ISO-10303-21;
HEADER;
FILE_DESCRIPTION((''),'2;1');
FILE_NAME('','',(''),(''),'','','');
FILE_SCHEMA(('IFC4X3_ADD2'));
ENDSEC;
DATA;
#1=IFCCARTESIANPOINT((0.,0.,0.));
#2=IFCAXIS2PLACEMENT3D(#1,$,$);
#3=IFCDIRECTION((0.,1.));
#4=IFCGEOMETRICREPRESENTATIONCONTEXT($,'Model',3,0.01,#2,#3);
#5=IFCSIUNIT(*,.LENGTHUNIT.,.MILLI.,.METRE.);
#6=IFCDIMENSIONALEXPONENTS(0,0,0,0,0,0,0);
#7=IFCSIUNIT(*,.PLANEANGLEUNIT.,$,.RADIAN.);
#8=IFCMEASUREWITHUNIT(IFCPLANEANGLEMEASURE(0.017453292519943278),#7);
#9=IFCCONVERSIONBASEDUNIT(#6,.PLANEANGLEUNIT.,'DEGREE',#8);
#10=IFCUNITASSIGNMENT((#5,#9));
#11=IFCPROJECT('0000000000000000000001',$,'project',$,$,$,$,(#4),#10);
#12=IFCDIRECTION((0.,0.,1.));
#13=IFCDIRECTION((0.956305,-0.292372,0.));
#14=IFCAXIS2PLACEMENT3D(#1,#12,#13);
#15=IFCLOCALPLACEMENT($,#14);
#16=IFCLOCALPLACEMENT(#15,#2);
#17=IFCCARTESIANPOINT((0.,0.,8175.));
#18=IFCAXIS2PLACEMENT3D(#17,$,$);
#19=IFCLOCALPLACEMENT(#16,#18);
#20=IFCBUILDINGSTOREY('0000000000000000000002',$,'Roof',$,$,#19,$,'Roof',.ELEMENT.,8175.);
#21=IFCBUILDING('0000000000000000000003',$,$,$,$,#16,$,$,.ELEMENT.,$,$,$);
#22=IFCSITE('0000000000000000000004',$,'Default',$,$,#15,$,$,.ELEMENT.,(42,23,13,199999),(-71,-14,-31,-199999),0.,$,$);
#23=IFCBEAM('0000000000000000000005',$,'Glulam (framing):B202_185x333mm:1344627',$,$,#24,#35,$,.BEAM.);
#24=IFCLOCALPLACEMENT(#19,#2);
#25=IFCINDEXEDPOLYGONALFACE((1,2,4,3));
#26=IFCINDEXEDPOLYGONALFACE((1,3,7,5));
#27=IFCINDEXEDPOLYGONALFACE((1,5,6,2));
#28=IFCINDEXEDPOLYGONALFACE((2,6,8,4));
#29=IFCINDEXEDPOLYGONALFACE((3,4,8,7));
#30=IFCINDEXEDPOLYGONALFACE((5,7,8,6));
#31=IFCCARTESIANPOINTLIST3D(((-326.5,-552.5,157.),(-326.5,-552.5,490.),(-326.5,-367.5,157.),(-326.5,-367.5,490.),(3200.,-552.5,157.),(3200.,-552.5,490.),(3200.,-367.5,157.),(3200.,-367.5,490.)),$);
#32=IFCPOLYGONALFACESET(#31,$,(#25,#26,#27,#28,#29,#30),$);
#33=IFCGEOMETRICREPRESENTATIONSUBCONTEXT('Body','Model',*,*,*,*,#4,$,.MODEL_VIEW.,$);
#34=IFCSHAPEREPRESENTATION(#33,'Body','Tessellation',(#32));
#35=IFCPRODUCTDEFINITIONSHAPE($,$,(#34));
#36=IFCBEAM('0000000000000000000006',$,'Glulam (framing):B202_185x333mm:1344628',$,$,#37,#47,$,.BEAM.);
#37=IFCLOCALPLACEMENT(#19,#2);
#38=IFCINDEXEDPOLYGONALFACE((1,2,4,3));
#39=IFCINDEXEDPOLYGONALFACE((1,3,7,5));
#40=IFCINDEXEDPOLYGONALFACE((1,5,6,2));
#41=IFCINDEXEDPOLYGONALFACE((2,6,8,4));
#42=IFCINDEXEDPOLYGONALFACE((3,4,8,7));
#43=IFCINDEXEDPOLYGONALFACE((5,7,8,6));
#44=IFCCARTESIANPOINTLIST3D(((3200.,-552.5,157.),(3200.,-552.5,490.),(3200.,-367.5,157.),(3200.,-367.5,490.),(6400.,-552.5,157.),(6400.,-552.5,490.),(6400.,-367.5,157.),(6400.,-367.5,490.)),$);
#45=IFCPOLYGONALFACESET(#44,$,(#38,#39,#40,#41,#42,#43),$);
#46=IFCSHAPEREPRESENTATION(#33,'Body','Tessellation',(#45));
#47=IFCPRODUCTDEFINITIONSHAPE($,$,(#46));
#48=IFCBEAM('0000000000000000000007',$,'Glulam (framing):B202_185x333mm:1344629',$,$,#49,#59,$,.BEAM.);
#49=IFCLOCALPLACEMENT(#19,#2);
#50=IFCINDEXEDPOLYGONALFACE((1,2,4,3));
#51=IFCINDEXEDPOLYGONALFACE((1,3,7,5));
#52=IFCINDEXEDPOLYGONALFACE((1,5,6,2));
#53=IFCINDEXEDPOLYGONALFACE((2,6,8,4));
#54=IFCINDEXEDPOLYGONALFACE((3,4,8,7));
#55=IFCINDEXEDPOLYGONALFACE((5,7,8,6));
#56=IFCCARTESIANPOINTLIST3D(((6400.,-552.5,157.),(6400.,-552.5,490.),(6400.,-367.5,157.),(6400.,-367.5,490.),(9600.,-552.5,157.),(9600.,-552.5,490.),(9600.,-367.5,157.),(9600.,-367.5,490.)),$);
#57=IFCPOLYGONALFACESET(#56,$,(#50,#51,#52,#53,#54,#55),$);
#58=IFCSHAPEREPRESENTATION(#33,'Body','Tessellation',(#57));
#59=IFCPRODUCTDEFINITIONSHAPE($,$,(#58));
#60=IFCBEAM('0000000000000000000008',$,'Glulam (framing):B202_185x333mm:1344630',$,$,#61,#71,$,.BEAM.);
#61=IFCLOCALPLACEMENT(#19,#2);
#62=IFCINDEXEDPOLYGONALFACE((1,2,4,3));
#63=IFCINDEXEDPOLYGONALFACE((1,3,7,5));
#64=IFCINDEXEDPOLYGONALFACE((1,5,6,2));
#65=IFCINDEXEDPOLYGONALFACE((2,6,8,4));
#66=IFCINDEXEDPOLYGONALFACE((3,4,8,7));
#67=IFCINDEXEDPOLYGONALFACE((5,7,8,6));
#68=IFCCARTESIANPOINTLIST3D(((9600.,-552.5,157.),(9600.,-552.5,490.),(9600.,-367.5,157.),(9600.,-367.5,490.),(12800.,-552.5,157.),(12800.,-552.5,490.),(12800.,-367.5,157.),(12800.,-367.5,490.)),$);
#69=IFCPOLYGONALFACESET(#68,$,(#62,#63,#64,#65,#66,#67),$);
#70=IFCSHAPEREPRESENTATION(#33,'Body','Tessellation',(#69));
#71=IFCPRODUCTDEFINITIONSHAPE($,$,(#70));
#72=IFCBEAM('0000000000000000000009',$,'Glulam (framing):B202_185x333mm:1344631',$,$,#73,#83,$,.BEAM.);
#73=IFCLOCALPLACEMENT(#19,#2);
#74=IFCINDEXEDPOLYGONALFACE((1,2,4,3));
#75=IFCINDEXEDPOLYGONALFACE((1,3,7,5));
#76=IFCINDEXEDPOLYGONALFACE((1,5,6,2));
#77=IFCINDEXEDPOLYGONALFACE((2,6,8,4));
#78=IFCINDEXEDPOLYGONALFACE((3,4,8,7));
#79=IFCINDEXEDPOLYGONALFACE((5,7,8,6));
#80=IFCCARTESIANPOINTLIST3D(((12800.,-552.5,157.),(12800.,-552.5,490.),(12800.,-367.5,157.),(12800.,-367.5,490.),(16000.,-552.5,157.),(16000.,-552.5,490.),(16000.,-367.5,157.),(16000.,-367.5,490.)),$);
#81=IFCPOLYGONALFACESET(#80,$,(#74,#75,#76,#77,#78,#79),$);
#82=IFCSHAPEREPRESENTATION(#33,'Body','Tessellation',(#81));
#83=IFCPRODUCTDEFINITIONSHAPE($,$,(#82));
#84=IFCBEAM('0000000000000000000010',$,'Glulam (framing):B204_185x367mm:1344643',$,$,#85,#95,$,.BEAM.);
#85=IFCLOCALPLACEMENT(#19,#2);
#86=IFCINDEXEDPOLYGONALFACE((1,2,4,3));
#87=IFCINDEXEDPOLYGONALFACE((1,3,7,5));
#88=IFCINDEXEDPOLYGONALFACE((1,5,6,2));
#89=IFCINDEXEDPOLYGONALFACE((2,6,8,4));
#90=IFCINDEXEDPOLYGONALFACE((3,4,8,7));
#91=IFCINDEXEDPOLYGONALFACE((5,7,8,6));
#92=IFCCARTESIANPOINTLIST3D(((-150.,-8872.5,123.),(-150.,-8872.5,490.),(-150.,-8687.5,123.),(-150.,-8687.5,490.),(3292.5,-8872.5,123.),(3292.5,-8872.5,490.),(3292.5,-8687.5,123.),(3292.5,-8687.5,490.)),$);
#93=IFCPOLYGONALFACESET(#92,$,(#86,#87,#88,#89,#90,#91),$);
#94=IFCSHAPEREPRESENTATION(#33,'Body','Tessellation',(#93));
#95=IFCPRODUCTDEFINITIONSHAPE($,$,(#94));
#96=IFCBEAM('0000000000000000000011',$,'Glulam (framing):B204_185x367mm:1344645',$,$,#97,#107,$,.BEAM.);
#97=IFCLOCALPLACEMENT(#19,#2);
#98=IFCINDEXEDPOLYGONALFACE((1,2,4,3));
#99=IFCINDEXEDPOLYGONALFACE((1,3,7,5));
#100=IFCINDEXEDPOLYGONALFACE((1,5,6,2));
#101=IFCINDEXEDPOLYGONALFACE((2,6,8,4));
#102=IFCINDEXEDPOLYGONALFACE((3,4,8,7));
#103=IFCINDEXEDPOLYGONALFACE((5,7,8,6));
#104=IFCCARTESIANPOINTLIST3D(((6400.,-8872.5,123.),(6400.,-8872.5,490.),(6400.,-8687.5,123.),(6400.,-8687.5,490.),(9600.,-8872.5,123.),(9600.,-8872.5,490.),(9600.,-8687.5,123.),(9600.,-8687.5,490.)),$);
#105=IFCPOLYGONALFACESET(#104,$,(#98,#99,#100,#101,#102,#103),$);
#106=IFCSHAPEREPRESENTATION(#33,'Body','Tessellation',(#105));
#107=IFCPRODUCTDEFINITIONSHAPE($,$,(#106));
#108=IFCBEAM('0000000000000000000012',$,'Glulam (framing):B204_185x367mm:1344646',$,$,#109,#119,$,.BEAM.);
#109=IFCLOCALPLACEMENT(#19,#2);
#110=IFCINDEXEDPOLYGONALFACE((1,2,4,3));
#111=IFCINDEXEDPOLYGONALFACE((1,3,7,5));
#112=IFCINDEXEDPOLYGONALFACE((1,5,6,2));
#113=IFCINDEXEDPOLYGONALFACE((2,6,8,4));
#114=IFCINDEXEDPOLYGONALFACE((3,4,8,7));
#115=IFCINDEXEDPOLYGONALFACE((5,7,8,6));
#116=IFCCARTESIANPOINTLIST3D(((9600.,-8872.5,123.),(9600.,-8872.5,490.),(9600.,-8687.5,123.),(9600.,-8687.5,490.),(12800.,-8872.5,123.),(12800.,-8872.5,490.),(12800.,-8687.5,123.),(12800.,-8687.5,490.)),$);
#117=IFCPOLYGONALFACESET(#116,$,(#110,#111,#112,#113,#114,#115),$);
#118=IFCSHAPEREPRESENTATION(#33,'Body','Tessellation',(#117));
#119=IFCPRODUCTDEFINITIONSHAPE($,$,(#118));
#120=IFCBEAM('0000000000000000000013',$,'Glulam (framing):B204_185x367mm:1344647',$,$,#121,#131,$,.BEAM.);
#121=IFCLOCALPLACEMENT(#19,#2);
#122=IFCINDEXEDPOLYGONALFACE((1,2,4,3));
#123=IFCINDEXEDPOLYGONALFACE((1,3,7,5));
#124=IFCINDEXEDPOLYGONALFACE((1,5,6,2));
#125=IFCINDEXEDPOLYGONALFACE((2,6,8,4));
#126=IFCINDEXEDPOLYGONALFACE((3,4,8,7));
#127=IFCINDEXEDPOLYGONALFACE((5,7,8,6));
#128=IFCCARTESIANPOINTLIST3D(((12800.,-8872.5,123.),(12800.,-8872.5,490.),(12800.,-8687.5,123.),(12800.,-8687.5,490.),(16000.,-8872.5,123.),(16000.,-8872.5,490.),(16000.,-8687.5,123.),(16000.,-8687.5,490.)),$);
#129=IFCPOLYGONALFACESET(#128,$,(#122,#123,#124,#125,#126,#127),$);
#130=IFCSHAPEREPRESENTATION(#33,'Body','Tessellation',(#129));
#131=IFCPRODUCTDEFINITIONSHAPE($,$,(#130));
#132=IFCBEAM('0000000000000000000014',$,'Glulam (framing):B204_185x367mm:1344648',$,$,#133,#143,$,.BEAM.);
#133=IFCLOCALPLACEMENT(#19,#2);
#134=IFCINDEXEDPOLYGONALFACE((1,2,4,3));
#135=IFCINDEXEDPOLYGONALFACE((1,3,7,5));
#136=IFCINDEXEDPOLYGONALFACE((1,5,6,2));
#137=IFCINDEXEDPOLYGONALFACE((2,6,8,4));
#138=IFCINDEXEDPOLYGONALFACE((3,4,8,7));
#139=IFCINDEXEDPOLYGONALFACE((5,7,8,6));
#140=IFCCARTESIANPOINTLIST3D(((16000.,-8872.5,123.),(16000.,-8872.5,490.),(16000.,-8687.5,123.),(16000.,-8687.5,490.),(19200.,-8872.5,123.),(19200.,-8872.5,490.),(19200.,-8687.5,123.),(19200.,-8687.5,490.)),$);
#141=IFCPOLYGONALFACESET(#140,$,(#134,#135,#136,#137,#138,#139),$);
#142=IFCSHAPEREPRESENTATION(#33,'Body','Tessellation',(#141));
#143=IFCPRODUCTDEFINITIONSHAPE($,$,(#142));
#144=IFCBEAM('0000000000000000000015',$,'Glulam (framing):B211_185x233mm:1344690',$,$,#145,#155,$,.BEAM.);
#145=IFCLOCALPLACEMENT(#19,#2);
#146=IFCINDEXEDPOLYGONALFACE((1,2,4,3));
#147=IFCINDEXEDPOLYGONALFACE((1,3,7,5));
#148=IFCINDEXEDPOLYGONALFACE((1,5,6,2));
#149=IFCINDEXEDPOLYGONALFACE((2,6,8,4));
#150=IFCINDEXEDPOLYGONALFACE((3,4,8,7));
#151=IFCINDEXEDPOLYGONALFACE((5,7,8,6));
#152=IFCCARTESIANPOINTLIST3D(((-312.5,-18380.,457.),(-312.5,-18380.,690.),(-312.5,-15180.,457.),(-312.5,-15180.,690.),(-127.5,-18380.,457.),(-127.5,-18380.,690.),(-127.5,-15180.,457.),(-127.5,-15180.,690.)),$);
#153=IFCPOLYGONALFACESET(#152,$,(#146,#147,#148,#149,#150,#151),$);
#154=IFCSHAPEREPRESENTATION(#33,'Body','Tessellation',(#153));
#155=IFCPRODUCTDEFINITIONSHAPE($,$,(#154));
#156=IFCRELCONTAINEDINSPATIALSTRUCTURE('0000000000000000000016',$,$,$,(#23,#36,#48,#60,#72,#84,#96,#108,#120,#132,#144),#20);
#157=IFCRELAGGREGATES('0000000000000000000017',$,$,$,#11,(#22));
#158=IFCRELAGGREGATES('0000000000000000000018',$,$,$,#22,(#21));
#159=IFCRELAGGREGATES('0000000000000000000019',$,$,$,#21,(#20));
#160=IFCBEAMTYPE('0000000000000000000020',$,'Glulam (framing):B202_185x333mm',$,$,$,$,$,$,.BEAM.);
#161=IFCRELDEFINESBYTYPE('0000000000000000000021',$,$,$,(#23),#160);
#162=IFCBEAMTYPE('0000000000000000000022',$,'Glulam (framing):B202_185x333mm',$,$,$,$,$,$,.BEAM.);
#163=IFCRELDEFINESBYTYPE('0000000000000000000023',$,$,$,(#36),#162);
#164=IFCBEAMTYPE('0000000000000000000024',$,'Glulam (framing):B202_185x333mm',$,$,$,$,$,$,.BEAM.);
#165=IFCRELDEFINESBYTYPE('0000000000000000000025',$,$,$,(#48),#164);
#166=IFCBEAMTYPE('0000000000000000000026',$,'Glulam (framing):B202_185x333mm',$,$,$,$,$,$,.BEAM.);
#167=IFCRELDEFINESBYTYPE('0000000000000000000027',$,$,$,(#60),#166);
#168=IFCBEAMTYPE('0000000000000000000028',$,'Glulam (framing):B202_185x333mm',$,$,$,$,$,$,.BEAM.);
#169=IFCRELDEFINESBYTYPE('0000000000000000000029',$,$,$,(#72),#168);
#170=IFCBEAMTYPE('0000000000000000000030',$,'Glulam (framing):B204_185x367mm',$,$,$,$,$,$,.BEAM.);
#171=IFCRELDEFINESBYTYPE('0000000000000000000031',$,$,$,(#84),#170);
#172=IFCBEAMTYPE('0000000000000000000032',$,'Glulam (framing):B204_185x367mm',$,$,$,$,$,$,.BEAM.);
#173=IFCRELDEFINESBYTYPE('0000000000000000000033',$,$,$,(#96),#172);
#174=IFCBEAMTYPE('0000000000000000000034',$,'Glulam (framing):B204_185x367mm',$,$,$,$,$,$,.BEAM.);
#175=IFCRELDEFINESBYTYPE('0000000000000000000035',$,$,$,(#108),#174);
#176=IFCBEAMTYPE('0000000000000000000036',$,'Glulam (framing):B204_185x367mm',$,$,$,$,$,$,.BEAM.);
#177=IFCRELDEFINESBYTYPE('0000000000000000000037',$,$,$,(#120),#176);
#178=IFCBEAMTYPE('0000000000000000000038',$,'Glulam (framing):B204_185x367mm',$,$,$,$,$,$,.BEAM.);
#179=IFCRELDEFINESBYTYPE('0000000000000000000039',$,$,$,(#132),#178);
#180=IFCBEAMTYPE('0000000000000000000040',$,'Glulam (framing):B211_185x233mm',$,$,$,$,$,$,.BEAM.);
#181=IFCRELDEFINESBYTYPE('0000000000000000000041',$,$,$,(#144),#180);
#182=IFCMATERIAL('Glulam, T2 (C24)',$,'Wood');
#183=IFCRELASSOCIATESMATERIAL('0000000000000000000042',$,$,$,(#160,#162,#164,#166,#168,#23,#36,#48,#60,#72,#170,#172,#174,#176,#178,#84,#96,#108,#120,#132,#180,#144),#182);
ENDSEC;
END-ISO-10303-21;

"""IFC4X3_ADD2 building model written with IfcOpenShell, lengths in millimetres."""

from ifc_helpers import new_model, entity, si_unit, converted_unit, direction, frame, origin, origin_2d_with_axis, place, context, subcontext, project, spatial, rectangle, extrude, source, transform, mapped, material, material_profile, profile_set, profile_usage, type_object, type_shapes, element, save


model = new_model("IFC4X3_ADD2")

# Units and contexts
model_context = context("Model", 3, precision=0.01, world=origin(), true_north=direction((0.0, 1.0)))
body_context = subcontext(model_context, "Body", "Model", "MODEL_VIEW")
ifc_project = project(units=[si_unit("LENGTHUNIT", "METRE", prefix="MILLI"), converted_unit("PLANEANGLEUNIT", "DEGREE", entity("IfcPlaneAngleMeasure", 0.017453292519943278), si_unit("PLANEANGLEUNIT", "RADIAN"), dimensions=[0, 0, 0, 0, 0, 0, 0])], contexts=[model_context])

# Site, building, storey
site_placement = place(None, frame((0.0, 0.0, 0.0), z_axis=(0.0, 0.0, 1.0), x_axis=(0.956305, -0.292372, 0.0)))
site = spatial("IfcSite", under=ifc_project, at=site_placement, Name="Default", CompositionType="ELEMENT", RefLatitude=(42, 23, 13, 199999), RefLongitude=(-71, -14, -31, -199999), RefElevation=0.0)
building_placement = place(site_placement, origin())
building = spatial("IfcBuilding", under=site, at=building_placement, CompositionType="ELEMENT")
storey_placement = place(building_placement, frame((0.0, 0.0, 8175.0)))
storey = spatial("IfcBuildingStorey", under=building, at=storey_placement, Name="Roof", LongName="Roof", CompositionType="ELEMENT", Elevation=8175.0)

# Beams
ifc_material_1 = material(Name="Glulam, T2 (C24)", Category="Wood")
ifc_material_profile_1 = material_profile(ifc_material_1, rectangle(XDim=3526.5, YDim=185.0, at=origin_2d_with_axis()), Name="B202_185x333mm")
ifc_profile_set_1 = profile_set([ifc_material_profile_1], Name="B202_185x333mm")
ifc_profile_usage_1 = profile_usage(ifc_profile_set_1, cardinal=8)
beam_type_1 = type_object("IfcBeamType", Name="Glulam (framing):B202_185x333mm", PredefinedType="BEAM", material=ifc_profile_set_1)
shared_shape_1 = source(origin(), body_context, "Body", "SweptSolid", [
    extrude(rectangle(XDim=3526.5, YDim=185.0, at=origin_2d_with_axis()), frame((163.2, 0.0, -166.5), z_axis=(0.0, 0.0, 1.0), x_axis=(-1.0, 0.0, 0.0)), (0.0, 0.0, 1.0), 333.0),
])
type_shapes(beam_type_1, [shared_shape_1])
beam_1_placement = place(storey_placement, frame((1600.0, -460.0, 323.5), z_axis=(0.0, 0.0, 1.0), x_axis=(-1.0, 0.0, 0.0)))
element("IfcBeam", 1, at=beam_1_placement, inside=storey, type_object=beam_type_1, material=ifc_profile_usage_1, Name="Glulam (framing):B202_185x333mm:1344627", PredefinedType="BEAM", context=body_context, shape_type="MappedRepresentation", body=[
    mapped(shared_shape_1, transform((0.0, 0.0, 0.0), scale=1.0)),
])
beam_type_2 = type_object("IfcBeamType", Name="Glulam (framing):B202_185x333mm", PredefinedType="BEAM", material=ifc_profile_set_1)
shared_shape_2 = source(origin(), body_context, "Body", "SweptSolid", [
    extrude(rectangle(XDim=3200.0, YDim=185.0, at=origin_2d_with_axis()), frame((0.0, 0.0, -166.5), z_axis=(0.0, 0.0, 1.0), x_axis=(-1.0, 0.0, 0.0)), (0.0, 0.0, 1.0), 333.0),
])
type_shapes(beam_type_2, [shared_shape_2])
beam_2_placement = place(storey_placement, frame((4800.0, -460.0, 323.5), z_axis=(0.0, 0.0, 1.0), x_axis=(-1.0, 0.0, 0.0)))
element("IfcBeam", 2, at=beam_2_placement, inside=storey, type_object=beam_type_2, material=ifc_profile_usage_1, Name="Glulam (framing):B202_185x333mm:1344628", PredefinedType="BEAM", context=body_context, shape_type="MappedRepresentation", body=[
    mapped(shared_shape_2, transform((0.0, 0.0, 0.0), scale=1.0)),
])
beam_type_3 = type_object("IfcBeamType", Name="Glulam (framing):B202_185x333mm", PredefinedType="BEAM", material=ifc_profile_set_1)
shared_shape_3 = source(origin(), body_context, "Body", "SweptSolid", [
    extrude(rectangle(XDim=3200.0, YDim=185.0, at=origin_2d_with_axis()), frame((0.0, 0.0, -166.5), z_axis=(0.0, 0.0, 1.0), x_axis=(-1.0, 0.0, 0.0)), (0.0, 0.0, 1.0), 333.0),
])
type_shapes(beam_type_3, [shared_shape_3])
beam_3_placement = place(storey_placement, frame((8000.0, -460.0, 323.5), z_axis=(0.0, 0.0, 1.0), x_axis=(-1.0, 0.0, 0.0)))
element("IfcBeam", 3, at=beam_3_placement, inside=storey, type_object=beam_type_3, material=ifc_profile_usage_1, Name="Glulam (framing):B202_185x333mm:1344629", PredefinedType="BEAM", context=body_context, shape_type="MappedRepresentation", body=[
    mapped(shared_shape_3, transform((0.0, 0.0, 0.0), scale=1.0)),
])
beam_type_4 = type_object("IfcBeamType", Name="Glulam (framing):B202_185x333mm", PredefinedType="BEAM", material=ifc_profile_set_1)
shared_shape_4 = source(origin(), body_context, "Body", "SweptSolid", [
    extrude(rectangle(XDim=3200.0, YDim=185.0, at=origin_2d_with_axis()), frame((0.0, 0.0, -166.5), z_axis=(0.0, 0.0, 1.0), x_axis=(-1.0, 0.0, 0.0)), (0.0, 0.0, 1.0), 333.0),
])
type_shapes(beam_type_4, [shared_shape_4])
beam_4_placement = place(storey_placement, frame((11200.0, -460.0, 323.5), z_axis=(0.0, 0.0, 1.0), x_axis=(-1.0, 0.0, 0.0)))
element("IfcBeam", 4, at=beam_4_placement, inside=storey, type_object=beam_type_4, material=ifc_profile_usage_1, Name="Glulam (framing):B202_185x333mm:1344630", PredefinedType="BEAM", context=body_context, shape_type="MappedRepresentation", body=[
    mapped(shared_shape_4, transform((0.0, 0.0, 0.0), scale=1.0)),
])
beam_type_5 = type_object("IfcBeamType", Name="Glulam (framing):B202_185x333mm", PredefinedType="BEAM", material=ifc_profile_set_1)
shared_shape_5 = source(origin(), body_context, "Body", "SweptSolid", [
    extrude(rectangle(XDim=3200.0, YDim=185.0, at=origin_2d_with_axis()), frame((0.0, 0.0, -166.5), z_axis=(0.0, 0.0, 1.0), x_axis=(-1.0, 0.0, 0.0)), (0.0, 0.0, 1.0), 333.0),
])
type_shapes(beam_type_5, [shared_shape_5])
beam_5_placement = place(storey_placement, frame((14400.0, -460.0, 323.5), z_axis=(0.0, 0.0, 1.0), x_axis=(-1.0, 0.0, 0.0)))
element("IfcBeam", 5, at=beam_5_placement, inside=storey, type_object=beam_type_5, material=ifc_profile_usage_1, Name="Glulam (framing):B202_185x333mm:1344631", PredefinedType="BEAM", context=body_context, shape_type="MappedRepresentation", body=[
    mapped(shared_shape_5, transform((0.0, 0.0, 0.0), scale=1.0)),
])
ifc_material_profile_2 = material_profile(ifc_material_1, rectangle(XDim=3442.5, YDim=185.0, at=origin_2d_with_axis()), Name="B204_185x367mm")
ifc_profile_set_2 = profile_set([ifc_material_profile_2], Name="B204_185x367mm")
ifc_profile_usage_2 = profile_usage(ifc_profile_set_2, cardinal=8)
beam_type_6 = type_object("IfcBeamType", Name="Glulam (framing):B204_185x367mm", PredefinedType="BEAM", material=ifc_profile_set_2)
shared_shape_6 = source(origin(), body_context, "Body", "SweptSolid", [
    extrude(rectangle(XDim=3442.5, YDim=185.0, at=origin_2d_with_axis()), frame((-28.8, 0.0, -183.5), z_axis=(0.0, 0.0, 1.0), x_axis=(-1.0, 0.0, 0.0)), (0.0, 0.0, 1.0), 367.0),
])
type_shapes(beam_type_6, [shared_shape_6])
beam_6_placement = place(storey_placement, frame((1600.0, -8780.0, 306.5)))
element("IfcBeam", 6, at=beam_6_placement, inside=storey, type_object=beam_type_6, material=ifc_profile_usage_2, Name="Glulam (framing):B204_185x367mm:1344643", PredefinedType="BEAM", context=body_context, shape_type="MappedRepresentation", body=[
    mapped(shared_shape_6, transform((0.0, 0.0, 0.0), scale=1.0)),
])
beam_type_7 = type_object("IfcBeamType", Name="Glulam (framing):B204_185x367mm", PredefinedType="BEAM", material=ifc_profile_set_2)
shared_shape_7 = source(origin(), body_context, "Body", "SweptSolid", [
    extrude(rectangle(XDim=3200.0, YDim=185.0, at=origin_2d_with_axis()), frame((0.0, 0.0, -183.5), z_axis=(0.0, 0.0, 1.0), x_axis=(-1.0, 0.0, 0.0)), (0.0, 0.0, 1.0), 367.0),
])
type_shapes(beam_type_7, [shared_shape_7])
beam_7_placement = place(storey_placement, frame((8000.0, -8780.0, 306.5)))
element("IfcBeam", 7, at=beam_7_placement, inside=storey, type_object=beam_type_7, material=ifc_profile_usage_2, Name="Glulam (framing):B204_185x367mm:1344645", PredefinedType="BEAM", context=body_context, shape_type="MappedRepresentation", body=[
    mapped(shared_shape_7, transform((0.0, 0.0, 0.0), scale=1.0)),
])
beam_type_8 = type_object("IfcBeamType", Name="Glulam (framing):B204_185x367mm", PredefinedType="BEAM", material=ifc_profile_set_2)
shared_shape_8 = source(origin(), body_context, "Body", "SweptSolid", [
    extrude(rectangle(XDim=3200.0, YDim=185.0, at=origin_2d_with_axis()), frame((0.0, 0.0, -183.5), z_axis=(0.0, 0.0, 1.0), x_axis=(-1.0, 0.0, 0.0)), (0.0, 0.0, 1.0), 367.0),
])
type_shapes(beam_type_8, [shared_shape_8])
beam_8_placement = place(storey_placement, frame((11200.0, -8780.0, 306.5)))
element("IfcBeam", 8, at=beam_8_placement, inside=storey, type_object=beam_type_8, material=ifc_profile_usage_2, Name="Glulam (framing):B204_185x367mm:1344646", PredefinedType="BEAM", context=body_context, shape_type="MappedRepresentation", body=[
    mapped(shared_shape_8, transform((0.0, 0.0, 0.0), scale=1.0)),
])
beam_type_9 = type_object("IfcBeamType", Name="Glulam (framing):B204_185x367mm", PredefinedType="BEAM", material=ifc_profile_set_2)
shared_shape_9 = source(origin(), body_context, "Body", "SweptSolid", [
    extrude(rectangle(XDim=3200.0, YDim=185.0, at=origin_2d_with_axis()), frame((0.0, 0.0, -183.5), z_axis=(0.0, 0.0, 1.0), x_axis=(-1.0, 0.0, 0.0)), (0.0, 0.0, 1.0), 367.0),
])
type_shapes(beam_type_9, [shared_shape_9])
beam_9_placement = place(storey_placement, frame((14400.0, -8780.0, 306.5)))
element("IfcBeam", 9, at=beam_9_placement, inside=storey, type_object=beam_type_9, material=ifc_profile_usage_2, Name="Glulam (framing):B204_185x367mm:1344647", PredefinedType="BEAM", context=body_context, shape_type="MappedRepresentation", body=[
    mapped(shared_shape_9, transform((0.0, 0.0, 0.0), scale=1.0)),
])
beam_type_10 = type_object("IfcBeamType", Name="Glulam (framing):B204_185x367mm", PredefinedType="BEAM", material=ifc_profile_set_2)
shared_shape_10 = source(origin(), body_context, "Body", "SweptSolid", [
    extrude(rectangle(XDim=3200.0, YDim=185.0, at=origin_2d_with_axis()), frame((0.0, 0.0, -183.5), z_axis=(0.0, 0.0, 1.0), x_axis=(-1.0, 0.0, 0.0)), (0.0, 0.0, 1.0), 367.0),
])
type_shapes(beam_type_10, [shared_shape_10])
beam_10_placement = place(storey_placement, frame((17600.0, -8780.0, 306.5)))
element("IfcBeam", 10, at=beam_10_placement, inside=storey, type_object=beam_type_10, material=ifc_profile_usage_2, Name="Glulam (framing):B204_185x367mm:1344648", PredefinedType="BEAM", context=body_context, shape_type="MappedRepresentation", body=[
    mapped(shared_shape_10, transform((0.0, 0.0, 0.0), scale=1.0)),
])
ifc_material_profile_3 = material_profile(ifc_material_1, rectangle(XDim=3200.0, YDim=185.0, at=origin_2d_with_axis()), Name="B211_185x233mm")
ifc_profile_set_3 = profile_set([ifc_material_profile_3], Name="B211_185x233mm")
ifc_profile_usage_3 = profile_usage(ifc_profile_set_3, cardinal=8)
beam_type_11 = type_object("IfcBeamType", Name="Glulam (framing):B211_185x233mm", PredefinedType="BEAM", material=ifc_profile_set_3)
shared_shape_11 = source(origin(), body_context, "Body", "SweptSolid", [
    extrude(rectangle(XDim=3200.0, YDim=185.0, at=origin_2d_with_axis()), frame((0.0, 0.0, -116.5), z_axis=(0.0, 0.0, 1.0), x_axis=(-1.0, 0.0, 0.0)), (0.0, 0.0, 1.0), 233.0),
])
type_shapes(beam_type_11, [shared_shape_11])
for number, where, z_axis, x_axis, name in (
    (11, (-220.0, -16780.0, 573.5), (0.0, 0.0, 1.0), (0.0, -1.0, 0.0), "Glulam (framing):B211_185x233mm:1344690"),
):
    element("IfcBeam", number, at=place(storey_placement, frame(where, z_axis=z_axis, x_axis=x_axis)), inside=storey, type_object=beam_type_11, material=ifc_profile_usage_3, Name=name, PredefinedType="BEAM", context=body_context, shape_type="MappedRepresentation", body=[
        mapped(shared_shape_11, transform((0.0, 0.0, 0.0), scale=1.0)),
    ])

save(model, "model.ifc")
